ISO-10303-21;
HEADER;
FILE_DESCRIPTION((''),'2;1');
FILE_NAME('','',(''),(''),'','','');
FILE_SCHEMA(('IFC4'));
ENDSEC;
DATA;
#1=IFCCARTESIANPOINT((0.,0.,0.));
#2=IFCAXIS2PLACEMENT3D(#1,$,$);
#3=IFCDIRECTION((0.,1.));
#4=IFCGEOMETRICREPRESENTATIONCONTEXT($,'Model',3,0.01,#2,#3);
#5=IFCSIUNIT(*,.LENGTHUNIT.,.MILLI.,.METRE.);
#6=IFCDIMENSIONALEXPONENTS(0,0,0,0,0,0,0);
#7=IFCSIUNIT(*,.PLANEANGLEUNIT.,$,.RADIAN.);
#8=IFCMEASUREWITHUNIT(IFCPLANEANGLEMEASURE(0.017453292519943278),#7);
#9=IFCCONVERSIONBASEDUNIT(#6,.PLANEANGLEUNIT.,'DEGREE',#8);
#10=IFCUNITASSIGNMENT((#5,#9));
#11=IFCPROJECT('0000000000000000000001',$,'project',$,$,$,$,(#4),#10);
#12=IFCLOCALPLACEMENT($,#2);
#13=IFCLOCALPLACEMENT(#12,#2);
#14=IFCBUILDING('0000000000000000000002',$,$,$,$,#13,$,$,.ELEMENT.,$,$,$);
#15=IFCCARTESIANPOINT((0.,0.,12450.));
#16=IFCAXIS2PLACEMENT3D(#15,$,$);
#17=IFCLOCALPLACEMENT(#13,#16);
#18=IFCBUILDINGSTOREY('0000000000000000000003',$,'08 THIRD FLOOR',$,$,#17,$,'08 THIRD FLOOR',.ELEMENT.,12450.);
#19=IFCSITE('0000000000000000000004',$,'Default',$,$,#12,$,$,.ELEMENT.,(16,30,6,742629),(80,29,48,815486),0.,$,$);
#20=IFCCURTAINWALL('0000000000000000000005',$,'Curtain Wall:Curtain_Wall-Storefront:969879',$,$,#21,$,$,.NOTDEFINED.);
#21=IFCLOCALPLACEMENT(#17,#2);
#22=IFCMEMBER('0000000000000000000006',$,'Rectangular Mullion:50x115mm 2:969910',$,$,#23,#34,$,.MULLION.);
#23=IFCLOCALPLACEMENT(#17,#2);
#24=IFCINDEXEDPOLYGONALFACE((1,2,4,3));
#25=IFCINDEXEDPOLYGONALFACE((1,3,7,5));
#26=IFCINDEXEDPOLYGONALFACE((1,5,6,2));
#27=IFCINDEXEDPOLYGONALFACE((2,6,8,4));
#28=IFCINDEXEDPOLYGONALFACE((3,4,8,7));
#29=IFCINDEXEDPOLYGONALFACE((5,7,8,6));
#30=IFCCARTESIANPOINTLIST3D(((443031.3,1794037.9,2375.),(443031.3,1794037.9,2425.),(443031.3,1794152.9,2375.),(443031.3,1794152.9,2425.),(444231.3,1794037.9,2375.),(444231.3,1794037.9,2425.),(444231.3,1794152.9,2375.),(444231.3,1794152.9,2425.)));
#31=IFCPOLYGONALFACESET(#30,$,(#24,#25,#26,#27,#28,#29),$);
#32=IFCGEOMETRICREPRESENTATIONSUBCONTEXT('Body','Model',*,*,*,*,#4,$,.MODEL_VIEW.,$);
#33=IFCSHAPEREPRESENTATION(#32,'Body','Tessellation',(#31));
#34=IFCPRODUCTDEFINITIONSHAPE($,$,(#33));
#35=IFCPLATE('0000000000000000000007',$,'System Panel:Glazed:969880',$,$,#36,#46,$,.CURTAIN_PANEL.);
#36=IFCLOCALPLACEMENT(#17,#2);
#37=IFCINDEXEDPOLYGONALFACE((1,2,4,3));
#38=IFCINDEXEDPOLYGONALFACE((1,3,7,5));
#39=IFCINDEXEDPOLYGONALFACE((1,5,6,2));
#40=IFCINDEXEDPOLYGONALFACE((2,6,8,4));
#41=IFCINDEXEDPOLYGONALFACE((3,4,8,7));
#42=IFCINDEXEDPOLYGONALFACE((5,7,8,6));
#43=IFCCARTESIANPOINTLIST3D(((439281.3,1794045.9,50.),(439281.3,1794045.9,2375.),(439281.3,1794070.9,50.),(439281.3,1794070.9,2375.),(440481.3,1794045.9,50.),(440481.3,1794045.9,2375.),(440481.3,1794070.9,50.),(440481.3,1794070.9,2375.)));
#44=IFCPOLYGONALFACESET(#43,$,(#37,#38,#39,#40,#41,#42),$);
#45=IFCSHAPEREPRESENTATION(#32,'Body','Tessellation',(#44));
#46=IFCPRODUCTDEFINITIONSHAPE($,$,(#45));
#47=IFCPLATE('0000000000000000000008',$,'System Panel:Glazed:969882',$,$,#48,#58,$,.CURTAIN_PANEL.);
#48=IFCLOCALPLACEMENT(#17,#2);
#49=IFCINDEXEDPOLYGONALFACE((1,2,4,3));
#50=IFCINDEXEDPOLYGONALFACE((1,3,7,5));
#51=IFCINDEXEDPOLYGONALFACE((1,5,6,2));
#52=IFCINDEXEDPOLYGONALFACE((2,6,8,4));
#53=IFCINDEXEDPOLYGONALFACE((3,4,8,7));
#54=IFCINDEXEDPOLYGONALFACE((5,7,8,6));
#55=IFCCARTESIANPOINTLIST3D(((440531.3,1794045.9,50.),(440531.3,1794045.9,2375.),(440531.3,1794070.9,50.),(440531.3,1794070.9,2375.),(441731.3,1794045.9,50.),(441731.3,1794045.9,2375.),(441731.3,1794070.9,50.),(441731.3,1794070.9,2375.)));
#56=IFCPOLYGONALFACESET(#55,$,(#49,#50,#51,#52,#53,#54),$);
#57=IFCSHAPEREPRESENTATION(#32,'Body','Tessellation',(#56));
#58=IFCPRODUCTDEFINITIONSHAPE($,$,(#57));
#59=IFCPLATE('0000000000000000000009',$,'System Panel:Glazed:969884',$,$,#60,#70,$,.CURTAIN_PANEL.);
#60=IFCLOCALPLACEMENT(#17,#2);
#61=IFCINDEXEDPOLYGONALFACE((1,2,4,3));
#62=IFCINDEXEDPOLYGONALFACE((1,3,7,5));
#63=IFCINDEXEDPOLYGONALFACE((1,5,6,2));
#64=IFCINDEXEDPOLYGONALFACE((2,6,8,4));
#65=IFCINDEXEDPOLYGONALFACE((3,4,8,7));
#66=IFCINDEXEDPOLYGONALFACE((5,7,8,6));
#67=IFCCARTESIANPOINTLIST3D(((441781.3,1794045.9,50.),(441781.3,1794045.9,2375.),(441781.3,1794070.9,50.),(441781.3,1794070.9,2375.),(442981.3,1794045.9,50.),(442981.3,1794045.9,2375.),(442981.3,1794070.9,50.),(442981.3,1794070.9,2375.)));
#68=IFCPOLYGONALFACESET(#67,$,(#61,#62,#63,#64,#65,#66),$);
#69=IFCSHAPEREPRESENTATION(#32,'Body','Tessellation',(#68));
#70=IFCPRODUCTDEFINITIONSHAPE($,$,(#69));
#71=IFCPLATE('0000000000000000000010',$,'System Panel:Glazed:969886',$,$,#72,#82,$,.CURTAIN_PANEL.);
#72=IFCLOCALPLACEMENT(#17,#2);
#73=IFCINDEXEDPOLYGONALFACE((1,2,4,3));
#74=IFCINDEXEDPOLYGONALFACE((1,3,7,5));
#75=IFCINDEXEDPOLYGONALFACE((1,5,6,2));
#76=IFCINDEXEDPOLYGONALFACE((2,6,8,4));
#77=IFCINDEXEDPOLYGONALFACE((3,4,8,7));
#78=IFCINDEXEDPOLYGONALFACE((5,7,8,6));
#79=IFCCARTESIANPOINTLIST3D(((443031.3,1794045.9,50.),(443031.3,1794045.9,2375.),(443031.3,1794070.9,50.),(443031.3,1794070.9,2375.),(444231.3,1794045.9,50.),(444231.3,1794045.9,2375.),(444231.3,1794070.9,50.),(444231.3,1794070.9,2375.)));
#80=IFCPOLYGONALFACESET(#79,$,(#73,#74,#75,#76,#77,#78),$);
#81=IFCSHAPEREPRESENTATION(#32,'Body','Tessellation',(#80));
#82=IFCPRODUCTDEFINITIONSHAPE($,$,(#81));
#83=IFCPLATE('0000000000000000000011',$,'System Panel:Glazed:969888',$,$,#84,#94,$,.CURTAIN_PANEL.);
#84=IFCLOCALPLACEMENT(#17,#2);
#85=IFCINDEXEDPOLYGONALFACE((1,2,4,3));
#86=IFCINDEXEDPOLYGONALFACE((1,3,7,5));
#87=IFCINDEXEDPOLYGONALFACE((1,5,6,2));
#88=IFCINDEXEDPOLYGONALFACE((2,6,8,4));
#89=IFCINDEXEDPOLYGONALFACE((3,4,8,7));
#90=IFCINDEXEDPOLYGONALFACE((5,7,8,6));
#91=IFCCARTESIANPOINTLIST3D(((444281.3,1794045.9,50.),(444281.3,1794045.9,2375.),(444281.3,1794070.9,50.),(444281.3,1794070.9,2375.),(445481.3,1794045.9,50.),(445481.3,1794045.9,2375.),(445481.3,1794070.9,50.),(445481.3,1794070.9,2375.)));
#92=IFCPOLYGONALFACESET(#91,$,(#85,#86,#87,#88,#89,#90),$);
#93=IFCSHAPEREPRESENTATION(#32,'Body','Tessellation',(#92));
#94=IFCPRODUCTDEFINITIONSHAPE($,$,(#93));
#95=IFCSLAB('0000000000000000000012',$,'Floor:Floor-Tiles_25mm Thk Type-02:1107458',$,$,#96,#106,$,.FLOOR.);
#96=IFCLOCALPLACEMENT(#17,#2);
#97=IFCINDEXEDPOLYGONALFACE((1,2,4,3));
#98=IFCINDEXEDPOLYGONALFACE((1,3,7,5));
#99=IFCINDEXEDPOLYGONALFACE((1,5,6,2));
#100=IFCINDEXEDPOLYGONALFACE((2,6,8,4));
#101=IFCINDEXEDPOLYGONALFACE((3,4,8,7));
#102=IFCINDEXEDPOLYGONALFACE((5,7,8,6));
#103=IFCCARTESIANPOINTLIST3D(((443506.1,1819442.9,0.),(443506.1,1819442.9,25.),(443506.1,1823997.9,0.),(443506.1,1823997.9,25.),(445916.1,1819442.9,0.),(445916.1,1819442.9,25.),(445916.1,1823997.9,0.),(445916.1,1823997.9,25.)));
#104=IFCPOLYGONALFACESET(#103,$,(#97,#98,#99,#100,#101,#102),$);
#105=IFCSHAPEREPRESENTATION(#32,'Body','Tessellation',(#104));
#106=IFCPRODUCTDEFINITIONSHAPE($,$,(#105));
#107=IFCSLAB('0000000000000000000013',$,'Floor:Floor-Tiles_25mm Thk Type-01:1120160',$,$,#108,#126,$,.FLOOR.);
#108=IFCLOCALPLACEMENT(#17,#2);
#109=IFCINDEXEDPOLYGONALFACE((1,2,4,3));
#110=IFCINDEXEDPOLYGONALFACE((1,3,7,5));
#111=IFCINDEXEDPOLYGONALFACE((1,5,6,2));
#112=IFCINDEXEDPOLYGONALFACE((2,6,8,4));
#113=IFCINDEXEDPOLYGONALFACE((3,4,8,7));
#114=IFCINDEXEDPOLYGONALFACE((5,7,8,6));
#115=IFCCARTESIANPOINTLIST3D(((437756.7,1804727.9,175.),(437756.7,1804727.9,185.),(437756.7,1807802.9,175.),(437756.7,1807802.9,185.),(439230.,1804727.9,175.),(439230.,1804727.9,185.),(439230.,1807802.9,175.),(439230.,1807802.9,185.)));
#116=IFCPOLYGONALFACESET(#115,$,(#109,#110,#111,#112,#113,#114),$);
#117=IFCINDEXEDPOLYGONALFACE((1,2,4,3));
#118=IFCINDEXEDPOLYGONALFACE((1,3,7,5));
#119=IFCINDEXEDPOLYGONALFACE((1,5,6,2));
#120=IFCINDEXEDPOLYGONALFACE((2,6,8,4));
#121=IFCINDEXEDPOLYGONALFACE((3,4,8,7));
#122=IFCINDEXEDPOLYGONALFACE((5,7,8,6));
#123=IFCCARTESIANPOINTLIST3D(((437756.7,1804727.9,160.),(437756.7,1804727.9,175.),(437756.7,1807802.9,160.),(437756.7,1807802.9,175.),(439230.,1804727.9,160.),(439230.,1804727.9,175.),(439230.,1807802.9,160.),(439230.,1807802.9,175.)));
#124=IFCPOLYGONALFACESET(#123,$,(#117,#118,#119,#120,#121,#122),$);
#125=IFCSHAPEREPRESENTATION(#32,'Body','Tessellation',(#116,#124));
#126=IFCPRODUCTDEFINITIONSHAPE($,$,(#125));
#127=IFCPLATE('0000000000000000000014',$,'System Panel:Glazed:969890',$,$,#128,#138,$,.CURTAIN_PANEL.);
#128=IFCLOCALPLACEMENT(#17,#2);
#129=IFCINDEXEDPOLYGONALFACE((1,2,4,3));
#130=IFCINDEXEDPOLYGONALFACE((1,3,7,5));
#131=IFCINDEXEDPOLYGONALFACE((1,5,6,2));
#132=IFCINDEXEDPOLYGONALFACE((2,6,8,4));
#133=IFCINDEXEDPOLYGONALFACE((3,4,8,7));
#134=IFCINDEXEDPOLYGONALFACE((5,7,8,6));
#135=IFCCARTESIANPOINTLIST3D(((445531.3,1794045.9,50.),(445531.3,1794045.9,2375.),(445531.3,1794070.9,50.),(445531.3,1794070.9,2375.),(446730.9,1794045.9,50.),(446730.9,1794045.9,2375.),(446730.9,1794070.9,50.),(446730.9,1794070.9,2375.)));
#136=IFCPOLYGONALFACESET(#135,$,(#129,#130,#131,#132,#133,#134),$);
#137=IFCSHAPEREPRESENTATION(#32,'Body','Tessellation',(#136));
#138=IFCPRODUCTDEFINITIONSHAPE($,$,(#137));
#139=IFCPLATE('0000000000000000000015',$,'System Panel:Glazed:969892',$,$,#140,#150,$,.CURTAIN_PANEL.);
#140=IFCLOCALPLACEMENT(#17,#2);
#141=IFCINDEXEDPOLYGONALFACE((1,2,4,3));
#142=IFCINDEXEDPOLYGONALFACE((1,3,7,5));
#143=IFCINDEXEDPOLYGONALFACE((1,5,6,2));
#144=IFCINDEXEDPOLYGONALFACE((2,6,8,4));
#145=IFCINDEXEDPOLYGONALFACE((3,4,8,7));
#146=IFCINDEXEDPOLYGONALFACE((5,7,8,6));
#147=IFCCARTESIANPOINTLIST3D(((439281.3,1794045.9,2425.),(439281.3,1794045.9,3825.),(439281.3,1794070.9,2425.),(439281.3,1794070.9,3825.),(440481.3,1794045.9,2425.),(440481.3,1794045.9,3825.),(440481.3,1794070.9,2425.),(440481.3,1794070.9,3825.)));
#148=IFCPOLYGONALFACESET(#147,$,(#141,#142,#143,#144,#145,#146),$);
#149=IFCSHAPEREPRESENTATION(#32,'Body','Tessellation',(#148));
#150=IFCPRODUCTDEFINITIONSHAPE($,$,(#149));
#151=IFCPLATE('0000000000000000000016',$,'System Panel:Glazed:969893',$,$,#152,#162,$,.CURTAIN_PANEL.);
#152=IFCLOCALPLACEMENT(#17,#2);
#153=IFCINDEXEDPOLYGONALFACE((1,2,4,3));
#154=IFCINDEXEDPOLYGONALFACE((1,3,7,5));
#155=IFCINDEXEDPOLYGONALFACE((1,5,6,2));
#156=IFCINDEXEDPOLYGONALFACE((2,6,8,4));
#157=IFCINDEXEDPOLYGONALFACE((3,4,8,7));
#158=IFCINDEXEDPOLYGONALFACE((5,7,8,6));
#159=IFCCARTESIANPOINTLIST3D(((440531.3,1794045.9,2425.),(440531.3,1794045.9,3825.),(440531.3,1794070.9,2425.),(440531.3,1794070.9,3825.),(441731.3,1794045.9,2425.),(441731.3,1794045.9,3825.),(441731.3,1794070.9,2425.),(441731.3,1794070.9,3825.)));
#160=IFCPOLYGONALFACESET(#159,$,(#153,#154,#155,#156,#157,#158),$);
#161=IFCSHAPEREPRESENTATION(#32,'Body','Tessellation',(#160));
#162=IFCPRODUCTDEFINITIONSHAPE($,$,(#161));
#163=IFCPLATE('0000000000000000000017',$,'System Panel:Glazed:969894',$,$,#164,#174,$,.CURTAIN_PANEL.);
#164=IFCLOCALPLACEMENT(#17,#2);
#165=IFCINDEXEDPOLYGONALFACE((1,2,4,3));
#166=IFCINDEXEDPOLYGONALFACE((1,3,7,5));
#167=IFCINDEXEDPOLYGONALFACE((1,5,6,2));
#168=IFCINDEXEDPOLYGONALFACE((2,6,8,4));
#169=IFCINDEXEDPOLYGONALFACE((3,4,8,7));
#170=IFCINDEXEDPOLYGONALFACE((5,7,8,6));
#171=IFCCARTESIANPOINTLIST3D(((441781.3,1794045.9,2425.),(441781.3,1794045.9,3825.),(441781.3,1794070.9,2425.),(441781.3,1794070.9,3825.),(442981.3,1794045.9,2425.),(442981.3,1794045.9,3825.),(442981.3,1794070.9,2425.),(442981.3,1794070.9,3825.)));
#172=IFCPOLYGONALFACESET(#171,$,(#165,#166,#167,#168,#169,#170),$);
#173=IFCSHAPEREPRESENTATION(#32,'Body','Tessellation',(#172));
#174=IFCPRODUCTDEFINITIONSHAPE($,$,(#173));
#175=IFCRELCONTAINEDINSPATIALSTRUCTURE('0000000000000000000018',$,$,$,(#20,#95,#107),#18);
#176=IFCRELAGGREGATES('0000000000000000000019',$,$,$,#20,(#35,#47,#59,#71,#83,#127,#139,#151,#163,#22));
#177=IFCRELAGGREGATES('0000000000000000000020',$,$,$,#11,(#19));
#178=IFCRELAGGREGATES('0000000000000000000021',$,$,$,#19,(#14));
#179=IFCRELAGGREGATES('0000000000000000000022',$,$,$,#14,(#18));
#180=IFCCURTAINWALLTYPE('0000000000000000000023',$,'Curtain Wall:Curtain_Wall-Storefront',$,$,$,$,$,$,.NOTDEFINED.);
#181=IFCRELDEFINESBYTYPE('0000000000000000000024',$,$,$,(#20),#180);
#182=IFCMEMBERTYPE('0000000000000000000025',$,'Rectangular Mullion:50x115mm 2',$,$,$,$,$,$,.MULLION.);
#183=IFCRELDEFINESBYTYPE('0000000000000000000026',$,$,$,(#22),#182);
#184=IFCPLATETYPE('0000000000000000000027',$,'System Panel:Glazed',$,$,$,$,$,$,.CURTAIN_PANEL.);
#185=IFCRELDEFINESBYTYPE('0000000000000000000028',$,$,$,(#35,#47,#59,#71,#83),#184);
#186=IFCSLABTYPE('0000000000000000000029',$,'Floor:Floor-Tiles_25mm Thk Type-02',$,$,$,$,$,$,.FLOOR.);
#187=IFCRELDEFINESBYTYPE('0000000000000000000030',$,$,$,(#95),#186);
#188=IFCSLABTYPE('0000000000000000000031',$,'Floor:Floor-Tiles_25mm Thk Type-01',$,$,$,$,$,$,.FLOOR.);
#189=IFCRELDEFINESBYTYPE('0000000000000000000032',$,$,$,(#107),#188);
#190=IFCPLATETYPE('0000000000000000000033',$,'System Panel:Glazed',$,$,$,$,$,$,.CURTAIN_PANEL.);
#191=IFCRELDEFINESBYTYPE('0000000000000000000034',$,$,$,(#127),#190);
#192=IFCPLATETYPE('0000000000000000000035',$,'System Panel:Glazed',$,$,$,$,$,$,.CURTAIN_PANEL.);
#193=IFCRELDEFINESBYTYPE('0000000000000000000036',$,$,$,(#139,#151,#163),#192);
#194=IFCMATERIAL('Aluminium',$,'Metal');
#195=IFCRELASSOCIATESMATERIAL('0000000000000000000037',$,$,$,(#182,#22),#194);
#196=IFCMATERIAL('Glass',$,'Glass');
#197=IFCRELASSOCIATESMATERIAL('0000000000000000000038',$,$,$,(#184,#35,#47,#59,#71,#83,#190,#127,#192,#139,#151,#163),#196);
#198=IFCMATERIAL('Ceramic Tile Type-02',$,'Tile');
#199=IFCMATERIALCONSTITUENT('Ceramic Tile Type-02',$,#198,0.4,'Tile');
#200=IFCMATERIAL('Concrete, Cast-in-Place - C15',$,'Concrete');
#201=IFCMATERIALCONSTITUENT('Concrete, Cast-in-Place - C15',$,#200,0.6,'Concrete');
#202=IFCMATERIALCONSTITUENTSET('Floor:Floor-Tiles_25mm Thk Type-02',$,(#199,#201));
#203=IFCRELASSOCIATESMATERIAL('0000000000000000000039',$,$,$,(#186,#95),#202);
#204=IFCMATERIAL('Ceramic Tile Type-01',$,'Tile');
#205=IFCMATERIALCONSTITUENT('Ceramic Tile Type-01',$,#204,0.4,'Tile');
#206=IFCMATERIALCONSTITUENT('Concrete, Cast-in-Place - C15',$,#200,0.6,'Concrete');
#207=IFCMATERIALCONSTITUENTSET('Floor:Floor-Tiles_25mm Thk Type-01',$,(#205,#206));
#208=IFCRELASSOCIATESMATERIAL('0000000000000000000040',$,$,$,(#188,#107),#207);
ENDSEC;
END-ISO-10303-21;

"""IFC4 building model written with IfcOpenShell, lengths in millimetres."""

from ifc_helpers import new_model, entity, si_unit, converted_unit, direction, frame, origin, place, context, subcontext, project, spatial, indexed_curve, outline, extrude, source, transform, mapped, material, constituent, constituent_set, type_object, type_shapes, element, aggregate, save


model = new_model("IFC4")

# Units and contexts
model_context = context("Model", 3, precision=0.01, world=origin(), true_north=direction((0.0, 1.0)))
body_context = subcontext(model_context, "Body", "Model", "MODEL_VIEW")
ifc_project = project(units=[si_unit("LENGTHUNIT", "METRE", prefix="MILLI"), converted_unit("PLANEANGLEUNIT", "DEGREE", entity("IfcPlaneAngleMeasure", 0.017453292519943278), si_unit("PLANEANGLEUNIT", "RADIAN"), dimensions=[0, 0, 0, 0, 0, 0, 0])], contexts=[model_context])

# Site, building, storey
site_placement = place(None, origin())
site = spatial("IfcSite", under=ifc_project, at=site_placement, Name="Default", CompositionType="ELEMENT", RefLatitude=(16, 30, 6, 742629), RefLongitude=(80, 29, 48, 815486), RefElevation=0.0)
building_placement = place(site_placement, origin())
building = spatial("IfcBuilding", under=site, at=building_placement, CompositionType="ELEMENT")
storey_placement = place(building_placement, frame((0.0, 0.0, 12450.0)))
storey = spatial("IfcBuildingStorey", under=building, at=storey_placement, Name="08 THIRD FLOOR", LongName="08 THIRD FLOOR", CompositionType="ELEMENT", Elevation=12450.0)

# Curtain wall, member, plates
curtain_wall_type = type_object("IfcCurtainWallType", Name="Curtain Wall:Curtain_Wall-Storefront", PredefinedType="NOTDEFINED")
curtain_wall_placement = place(storey_placement, frame((0.0, 0.0, -12450.0)))
curtain_wall = element("IfcCurtainWall", 1, at=curtain_wall_placement, inside=storey, type_object=curtain_wall_type, Name="Curtain Wall:Curtain_Wall-Storefront:969879", PredefinedType="NOTDEFINED")
ifc_material_1 = material(Name="Aluminium", Category="Metal")
member_type_1 = type_object("IfcMemberType", Name="Rectangular Mullion:50x115mm 2", PredefinedType="MULLION", material=ifc_material_1)
shared_shape_1 = source(origin(), body_context, "Body", "SweptSolid", [
    extrude(outline(indexed_curve([(-25.0, -57.5), (25.0, -57.5), (25.0, 57.5), (-25.0, 57.5), (-25.0, -57.5)], self_intersect=False)), frame((0.0, 0.0, -1200.0), z_axis=(0.0, 0.0, 1.0), x_axis=(-1.0, 0.0, 0.0)), (0.0, 0.0, 1.0), 1200.0),
])
type_shapes(member_type_1, [shared_shape_1])
member_1_placement = place(curtain_wall_placement, frame((444231.3, 1794095.4, 14850.0), z_axis=(1.0, 0.0, 0.0), x_axis=(0.0, 0.0, 1.0)))
member_1 = element("IfcMember", 2, at=member_1_placement, type_object=member_type_1, material=ifc_material_1, Name="Rectangular Mullion:50x115mm 2:969910", PredefinedType="MULLION", context=body_context, shape_type="MappedRepresentation", body=[
    mapped(shared_shape_1, transform((0.0, 0.0, 0.0), scale=1.0)),
])
ifc_material_2 = material(Name="Glass", Category="Glass")
plate_type_1 = type_object("IfcPlateType", Name="System Panel:Glazed", PredefinedType="CURTAIN_PANEL", material=ifc_material_2)
shared_shape_2 = source(origin(), body_context, "Body", "SweptSolid", [
    extrude(outline(indexed_curve([(-12.5, -600.0), (12.5, -600.0), (12.5, 600.0), (-12.5, 600.0), (-12.5, -600.0)], self_intersect=False)), frame((0.0, -37.0, 0.0), z_axis=(0.0, 0.0, 1.0), x_axis=(0.0, 1.0, 0.0)), (0.0, 0.0, 1.0), 2325.0),
])
type_shapes(plate_type_1, [shared_shape_2])
plate_1_placement = place(curtain_wall_placement, frame((439881.3, 1794095.4, 12500.0)))
plate_1 = element("IfcPlate", 3, at=plate_1_placement, type_object=plate_type_1, material=ifc_material_2, Name="System Panel:Glazed:969880", PredefinedType="CURTAIN_PANEL", context=body_context, shape_type="MappedRepresentation", body=[
    mapped(shared_shape_2, transform((0.0, 0.0, 0.0), scale=1.0)),
])
plate_2_placement = place(curtain_wall_placement, frame((441131.3, 1794095.4, 12500.0)))
plate_2 = element("IfcPlate", 4, at=plate_2_placement, type_object=plate_type_1, material=ifc_material_2, Name="System Panel:Glazed:969882", PredefinedType="CURTAIN_PANEL", context=body_context, shape_type="MappedRepresentation", body=[
    mapped(shared_shape_2, transform((0.0, 0.0, 0.0), scale=1.0)),
])
plate_3_placement = place(curtain_wall_placement, frame((442381.3, 1794095.4, 12500.0)))
plate_3 = element("IfcPlate", 5, at=plate_3_placement, type_object=plate_type_1, material=ifc_material_2, Name="System Panel:Glazed:969884", PredefinedType="CURTAIN_PANEL", context=body_context, shape_type="MappedRepresentation", body=[
    mapped(shared_shape_2, transform((0.0, 0.0, 0.0), scale=1.0)),
])
plate_4_placement = place(curtain_wall_placement, frame((443631.3, 1794095.4, 12500.0)))
plate_4 = element("IfcPlate", 6, at=plate_4_placement, type_object=plate_type_1, material=ifc_material_2, Name="System Panel:Glazed:969886", PredefinedType="CURTAIN_PANEL", context=body_context, shape_type="MappedRepresentation", body=[
    mapped(shared_shape_2, transform((0.0, 0.0, 0.0), scale=1.0)),
])
plate_5_placement = place(curtain_wall_placement, frame((444881.3, 1794095.4, 12500.0)))
plate_5 = element("IfcPlate", 7, at=plate_5_placement, type_object=plate_type_1, material=ifc_material_2, Name="System Panel:Glazed:969888", PredefinedType="CURTAIN_PANEL", context=body_context, shape_type="MappedRepresentation", body=[
    mapped(shared_shape_2, transform((0.0, 0.0, 0.0), scale=1.0)),
])

# Slabs
ifc_material_3 = material(Name="Ceramic Tile Type-02", Category="Tile")
ifc_constituent_1 = constituent(ifc_material_3, Name="Ceramic Tile Type-02", Category="Tile", fraction=0.4)
ifc_material_4 = material(Name="Concrete, Cast-in-Place - C15", Category="Concrete")
ifc_constituent_2 = constituent(ifc_material_4, Name="Concrete, Cast-in-Place - C15", Category="Concrete", fraction=0.6)
ifc_constituent_set_1 = constituent_set(constituents=[ifc_constituent_1, ifc_constituent_2], Name="Floor:Floor-Tiles_25mm Thk Type-02")
slab_type_1 = type_object("IfcSlabType", Name="Floor:Floor-Tiles_25mm Thk Type-02", PredefinedType="FLOOR", material=ifc_constituent_set_1)
slab_1_placement = place(storey_placement, origin())
element("IfcSlab", 8, at=slab_1_placement, inside=storey, type_object=slab_type_1, material=ifc_constituent_set_1, Name="Floor:Floor-Tiles_25mm Thk Type-02:1107458", PredefinedType="FLOOR", context=body_context, shape_type="SweptSolid", body=[
    extrude(outline(indexed_curve([(-2277.5, -1205.0), (2277.5, -1205.0), (2277.5, 1205.0), (-2277.5, 1205.0), (-2277.5, -1205.0)], self_intersect=False)), frame((444711.1, 1821720.4, 25.0), z_axis=(0.0, 0.0, -1.0), x_axis=(0.0, 1.0, 0.0)), (0.0, 0.0, 1.0), 25.0),
])
ifc_material_5 = material(Name="Ceramic Tile Type-01", Category="Tile")
ifc_constituent_3 = constituent(ifc_material_5, Name="Ceramic Tile Type-01", Category="Tile", fraction=0.4)
ifc_constituent_4 = constituent(ifc_material_4, Name="Concrete, Cast-in-Place - C15", Category="Concrete", fraction=0.6)
ifc_constituent_set_2 = constituent_set(constituents=[ifc_constituent_3, ifc_constituent_4], Name="Floor:Floor-Tiles_25mm Thk Type-01")
slab_type_2 = type_object("IfcSlabType", Name="Floor:Floor-Tiles_25mm Thk Type-01", PredefinedType="FLOOR", material=ifc_constituent_set_2)
slab_2_placement = place(storey_placement, origin())
element("IfcSlab", 9, at=slab_2_placement, inside=storey, type_object=slab_type_2, material=ifc_constituent_set_2, Name="Floor:Floor-Tiles_25mm Thk Type-01:1120160", PredefinedType="FLOOR", context=body_context, shape_type="SweptSolid", body=[
    extrude(outline(indexed_curve([(-1537.5, -736.7), (1537.5, -736.7), (1537.5, 736.7), (-1537.5, 736.7), (-1537.5, -736.7)], self_intersect=False)), frame((438493.3, 1806265.4, 175.0), z_axis=(0.0, 0.0, 1.0), x_axis=(0.0, 1.0, 0.0)), (0.0, 0.0, 1.0), 10.0),
    extrude(outline(indexed_curve([(-1537.5, -736.7), (1537.5, -736.7), (1537.5, 736.7), (-1537.5, 736.7), (-1537.5, -736.7)], self_intersect=False)), frame((438493.3, 1806265.4, 160.0), z_axis=(0.0, 0.0, 1.0), x_axis=(0.0, 1.0, 0.0)), (0.0, 0.0, 1.0), 15.0),
])

# Plates
plate_type_2 = type_object("IfcPlateType", Name="System Panel:Glazed", PredefinedType="CURTAIN_PANEL", material=ifc_material_2)
shared_shape_3 = source(origin(), body_context, "Body", "SweptSolid", [
    extrude(outline(indexed_curve([(-12.5, -599.8), (12.5, -599.8), (12.5, 599.8), (-12.5, 599.8), (-12.5, -599.8)], self_intersect=False)), frame((0.0, -37.0, 0.0), z_axis=(0.0, 0.0, 1.0), x_axis=(0.0, 1.0, 0.0)), (0.0, 0.0, 1.0), 2325.0),
])
type_shapes(plate_type_2, [shared_shape_3])
plate_6_placement = place(curtain_wall_placement, frame((446131.1, 1794095.4, 12500.0)))
plate_6 = element("IfcPlate", 10, at=plate_6_placement, type_object=plate_type_2, material=ifc_material_2, Name="System Panel:Glazed:969890", PredefinedType="CURTAIN_PANEL", context=body_context, shape_type="MappedRepresentation", body=[
    mapped(shared_shape_3, transform((0.0, 0.0, 0.0), scale=1.0)),
])
plate_type_3 = type_object("IfcPlateType", Name="System Panel:Glazed", PredefinedType="CURTAIN_PANEL", material=ifc_material_2)
shared_shape_4 = source(origin(), body_context, "Body", "SweptSolid", [
    extrude(outline(indexed_curve([(-12.5, -600.0), (12.5, -600.0), (12.5, 600.0), (-12.5, 600.0), (-12.5, -600.0)], self_intersect=False)), frame((0.0, -37.0, 0.0), z_axis=(0.0, 0.0, 1.0), x_axis=(0.0, 1.0, 0.0)), (0.0, 0.0, 1.0), 1400.0),
])
type_shapes(plate_type_3, [shared_shape_4])
plate_7_placement = place(curtain_wall_placement, frame((439881.3, 1794095.4, 14875.0)))
plate_7 = element("IfcPlate", 11, at=plate_7_placement, type_object=plate_type_3, material=ifc_material_2, Name="System Panel:Glazed:969892", PredefinedType="CURTAIN_PANEL", context=body_context, shape_type="MappedRepresentation", body=[
    mapped(shared_shape_4, transform((0.0, 0.0, 0.0), scale=1.0)),
])
plate_8_placement = place(curtain_wall_placement, frame((441131.3, 1794095.4, 14875.0)))
plate_8 = element("IfcPlate", 12, at=plate_8_placement, type_object=plate_type_3, material=ifc_material_2, Name="System Panel:Glazed:969893", PredefinedType="CURTAIN_PANEL", context=body_context, shape_type="MappedRepresentation", body=[
    mapped(shared_shape_4, transform((0.0, 0.0, 0.0), scale=1.0)),
])
plate_9_placement = place(curtain_wall_placement, frame((442381.3, 1794095.4, 14875.0)))
plate_9 = element("IfcPlate", 13, at=plate_9_placement, type_object=plate_type_3, material=ifc_material_2, Name="System Panel:Glazed:969894", PredefinedType="CURTAIN_PANEL", context=body_context, shape_type="MappedRepresentation", body=[
    mapped(shared_shape_4, transform((0.0, 0.0, 0.0), scale=1.0)),
])
aggregate(curtain_wall, [plate_1, plate_2, plate_3, plate_4, plate_5, plate_6, plate_7, plate_8, plate_9, member_1])

save(model, "model.ifc")
